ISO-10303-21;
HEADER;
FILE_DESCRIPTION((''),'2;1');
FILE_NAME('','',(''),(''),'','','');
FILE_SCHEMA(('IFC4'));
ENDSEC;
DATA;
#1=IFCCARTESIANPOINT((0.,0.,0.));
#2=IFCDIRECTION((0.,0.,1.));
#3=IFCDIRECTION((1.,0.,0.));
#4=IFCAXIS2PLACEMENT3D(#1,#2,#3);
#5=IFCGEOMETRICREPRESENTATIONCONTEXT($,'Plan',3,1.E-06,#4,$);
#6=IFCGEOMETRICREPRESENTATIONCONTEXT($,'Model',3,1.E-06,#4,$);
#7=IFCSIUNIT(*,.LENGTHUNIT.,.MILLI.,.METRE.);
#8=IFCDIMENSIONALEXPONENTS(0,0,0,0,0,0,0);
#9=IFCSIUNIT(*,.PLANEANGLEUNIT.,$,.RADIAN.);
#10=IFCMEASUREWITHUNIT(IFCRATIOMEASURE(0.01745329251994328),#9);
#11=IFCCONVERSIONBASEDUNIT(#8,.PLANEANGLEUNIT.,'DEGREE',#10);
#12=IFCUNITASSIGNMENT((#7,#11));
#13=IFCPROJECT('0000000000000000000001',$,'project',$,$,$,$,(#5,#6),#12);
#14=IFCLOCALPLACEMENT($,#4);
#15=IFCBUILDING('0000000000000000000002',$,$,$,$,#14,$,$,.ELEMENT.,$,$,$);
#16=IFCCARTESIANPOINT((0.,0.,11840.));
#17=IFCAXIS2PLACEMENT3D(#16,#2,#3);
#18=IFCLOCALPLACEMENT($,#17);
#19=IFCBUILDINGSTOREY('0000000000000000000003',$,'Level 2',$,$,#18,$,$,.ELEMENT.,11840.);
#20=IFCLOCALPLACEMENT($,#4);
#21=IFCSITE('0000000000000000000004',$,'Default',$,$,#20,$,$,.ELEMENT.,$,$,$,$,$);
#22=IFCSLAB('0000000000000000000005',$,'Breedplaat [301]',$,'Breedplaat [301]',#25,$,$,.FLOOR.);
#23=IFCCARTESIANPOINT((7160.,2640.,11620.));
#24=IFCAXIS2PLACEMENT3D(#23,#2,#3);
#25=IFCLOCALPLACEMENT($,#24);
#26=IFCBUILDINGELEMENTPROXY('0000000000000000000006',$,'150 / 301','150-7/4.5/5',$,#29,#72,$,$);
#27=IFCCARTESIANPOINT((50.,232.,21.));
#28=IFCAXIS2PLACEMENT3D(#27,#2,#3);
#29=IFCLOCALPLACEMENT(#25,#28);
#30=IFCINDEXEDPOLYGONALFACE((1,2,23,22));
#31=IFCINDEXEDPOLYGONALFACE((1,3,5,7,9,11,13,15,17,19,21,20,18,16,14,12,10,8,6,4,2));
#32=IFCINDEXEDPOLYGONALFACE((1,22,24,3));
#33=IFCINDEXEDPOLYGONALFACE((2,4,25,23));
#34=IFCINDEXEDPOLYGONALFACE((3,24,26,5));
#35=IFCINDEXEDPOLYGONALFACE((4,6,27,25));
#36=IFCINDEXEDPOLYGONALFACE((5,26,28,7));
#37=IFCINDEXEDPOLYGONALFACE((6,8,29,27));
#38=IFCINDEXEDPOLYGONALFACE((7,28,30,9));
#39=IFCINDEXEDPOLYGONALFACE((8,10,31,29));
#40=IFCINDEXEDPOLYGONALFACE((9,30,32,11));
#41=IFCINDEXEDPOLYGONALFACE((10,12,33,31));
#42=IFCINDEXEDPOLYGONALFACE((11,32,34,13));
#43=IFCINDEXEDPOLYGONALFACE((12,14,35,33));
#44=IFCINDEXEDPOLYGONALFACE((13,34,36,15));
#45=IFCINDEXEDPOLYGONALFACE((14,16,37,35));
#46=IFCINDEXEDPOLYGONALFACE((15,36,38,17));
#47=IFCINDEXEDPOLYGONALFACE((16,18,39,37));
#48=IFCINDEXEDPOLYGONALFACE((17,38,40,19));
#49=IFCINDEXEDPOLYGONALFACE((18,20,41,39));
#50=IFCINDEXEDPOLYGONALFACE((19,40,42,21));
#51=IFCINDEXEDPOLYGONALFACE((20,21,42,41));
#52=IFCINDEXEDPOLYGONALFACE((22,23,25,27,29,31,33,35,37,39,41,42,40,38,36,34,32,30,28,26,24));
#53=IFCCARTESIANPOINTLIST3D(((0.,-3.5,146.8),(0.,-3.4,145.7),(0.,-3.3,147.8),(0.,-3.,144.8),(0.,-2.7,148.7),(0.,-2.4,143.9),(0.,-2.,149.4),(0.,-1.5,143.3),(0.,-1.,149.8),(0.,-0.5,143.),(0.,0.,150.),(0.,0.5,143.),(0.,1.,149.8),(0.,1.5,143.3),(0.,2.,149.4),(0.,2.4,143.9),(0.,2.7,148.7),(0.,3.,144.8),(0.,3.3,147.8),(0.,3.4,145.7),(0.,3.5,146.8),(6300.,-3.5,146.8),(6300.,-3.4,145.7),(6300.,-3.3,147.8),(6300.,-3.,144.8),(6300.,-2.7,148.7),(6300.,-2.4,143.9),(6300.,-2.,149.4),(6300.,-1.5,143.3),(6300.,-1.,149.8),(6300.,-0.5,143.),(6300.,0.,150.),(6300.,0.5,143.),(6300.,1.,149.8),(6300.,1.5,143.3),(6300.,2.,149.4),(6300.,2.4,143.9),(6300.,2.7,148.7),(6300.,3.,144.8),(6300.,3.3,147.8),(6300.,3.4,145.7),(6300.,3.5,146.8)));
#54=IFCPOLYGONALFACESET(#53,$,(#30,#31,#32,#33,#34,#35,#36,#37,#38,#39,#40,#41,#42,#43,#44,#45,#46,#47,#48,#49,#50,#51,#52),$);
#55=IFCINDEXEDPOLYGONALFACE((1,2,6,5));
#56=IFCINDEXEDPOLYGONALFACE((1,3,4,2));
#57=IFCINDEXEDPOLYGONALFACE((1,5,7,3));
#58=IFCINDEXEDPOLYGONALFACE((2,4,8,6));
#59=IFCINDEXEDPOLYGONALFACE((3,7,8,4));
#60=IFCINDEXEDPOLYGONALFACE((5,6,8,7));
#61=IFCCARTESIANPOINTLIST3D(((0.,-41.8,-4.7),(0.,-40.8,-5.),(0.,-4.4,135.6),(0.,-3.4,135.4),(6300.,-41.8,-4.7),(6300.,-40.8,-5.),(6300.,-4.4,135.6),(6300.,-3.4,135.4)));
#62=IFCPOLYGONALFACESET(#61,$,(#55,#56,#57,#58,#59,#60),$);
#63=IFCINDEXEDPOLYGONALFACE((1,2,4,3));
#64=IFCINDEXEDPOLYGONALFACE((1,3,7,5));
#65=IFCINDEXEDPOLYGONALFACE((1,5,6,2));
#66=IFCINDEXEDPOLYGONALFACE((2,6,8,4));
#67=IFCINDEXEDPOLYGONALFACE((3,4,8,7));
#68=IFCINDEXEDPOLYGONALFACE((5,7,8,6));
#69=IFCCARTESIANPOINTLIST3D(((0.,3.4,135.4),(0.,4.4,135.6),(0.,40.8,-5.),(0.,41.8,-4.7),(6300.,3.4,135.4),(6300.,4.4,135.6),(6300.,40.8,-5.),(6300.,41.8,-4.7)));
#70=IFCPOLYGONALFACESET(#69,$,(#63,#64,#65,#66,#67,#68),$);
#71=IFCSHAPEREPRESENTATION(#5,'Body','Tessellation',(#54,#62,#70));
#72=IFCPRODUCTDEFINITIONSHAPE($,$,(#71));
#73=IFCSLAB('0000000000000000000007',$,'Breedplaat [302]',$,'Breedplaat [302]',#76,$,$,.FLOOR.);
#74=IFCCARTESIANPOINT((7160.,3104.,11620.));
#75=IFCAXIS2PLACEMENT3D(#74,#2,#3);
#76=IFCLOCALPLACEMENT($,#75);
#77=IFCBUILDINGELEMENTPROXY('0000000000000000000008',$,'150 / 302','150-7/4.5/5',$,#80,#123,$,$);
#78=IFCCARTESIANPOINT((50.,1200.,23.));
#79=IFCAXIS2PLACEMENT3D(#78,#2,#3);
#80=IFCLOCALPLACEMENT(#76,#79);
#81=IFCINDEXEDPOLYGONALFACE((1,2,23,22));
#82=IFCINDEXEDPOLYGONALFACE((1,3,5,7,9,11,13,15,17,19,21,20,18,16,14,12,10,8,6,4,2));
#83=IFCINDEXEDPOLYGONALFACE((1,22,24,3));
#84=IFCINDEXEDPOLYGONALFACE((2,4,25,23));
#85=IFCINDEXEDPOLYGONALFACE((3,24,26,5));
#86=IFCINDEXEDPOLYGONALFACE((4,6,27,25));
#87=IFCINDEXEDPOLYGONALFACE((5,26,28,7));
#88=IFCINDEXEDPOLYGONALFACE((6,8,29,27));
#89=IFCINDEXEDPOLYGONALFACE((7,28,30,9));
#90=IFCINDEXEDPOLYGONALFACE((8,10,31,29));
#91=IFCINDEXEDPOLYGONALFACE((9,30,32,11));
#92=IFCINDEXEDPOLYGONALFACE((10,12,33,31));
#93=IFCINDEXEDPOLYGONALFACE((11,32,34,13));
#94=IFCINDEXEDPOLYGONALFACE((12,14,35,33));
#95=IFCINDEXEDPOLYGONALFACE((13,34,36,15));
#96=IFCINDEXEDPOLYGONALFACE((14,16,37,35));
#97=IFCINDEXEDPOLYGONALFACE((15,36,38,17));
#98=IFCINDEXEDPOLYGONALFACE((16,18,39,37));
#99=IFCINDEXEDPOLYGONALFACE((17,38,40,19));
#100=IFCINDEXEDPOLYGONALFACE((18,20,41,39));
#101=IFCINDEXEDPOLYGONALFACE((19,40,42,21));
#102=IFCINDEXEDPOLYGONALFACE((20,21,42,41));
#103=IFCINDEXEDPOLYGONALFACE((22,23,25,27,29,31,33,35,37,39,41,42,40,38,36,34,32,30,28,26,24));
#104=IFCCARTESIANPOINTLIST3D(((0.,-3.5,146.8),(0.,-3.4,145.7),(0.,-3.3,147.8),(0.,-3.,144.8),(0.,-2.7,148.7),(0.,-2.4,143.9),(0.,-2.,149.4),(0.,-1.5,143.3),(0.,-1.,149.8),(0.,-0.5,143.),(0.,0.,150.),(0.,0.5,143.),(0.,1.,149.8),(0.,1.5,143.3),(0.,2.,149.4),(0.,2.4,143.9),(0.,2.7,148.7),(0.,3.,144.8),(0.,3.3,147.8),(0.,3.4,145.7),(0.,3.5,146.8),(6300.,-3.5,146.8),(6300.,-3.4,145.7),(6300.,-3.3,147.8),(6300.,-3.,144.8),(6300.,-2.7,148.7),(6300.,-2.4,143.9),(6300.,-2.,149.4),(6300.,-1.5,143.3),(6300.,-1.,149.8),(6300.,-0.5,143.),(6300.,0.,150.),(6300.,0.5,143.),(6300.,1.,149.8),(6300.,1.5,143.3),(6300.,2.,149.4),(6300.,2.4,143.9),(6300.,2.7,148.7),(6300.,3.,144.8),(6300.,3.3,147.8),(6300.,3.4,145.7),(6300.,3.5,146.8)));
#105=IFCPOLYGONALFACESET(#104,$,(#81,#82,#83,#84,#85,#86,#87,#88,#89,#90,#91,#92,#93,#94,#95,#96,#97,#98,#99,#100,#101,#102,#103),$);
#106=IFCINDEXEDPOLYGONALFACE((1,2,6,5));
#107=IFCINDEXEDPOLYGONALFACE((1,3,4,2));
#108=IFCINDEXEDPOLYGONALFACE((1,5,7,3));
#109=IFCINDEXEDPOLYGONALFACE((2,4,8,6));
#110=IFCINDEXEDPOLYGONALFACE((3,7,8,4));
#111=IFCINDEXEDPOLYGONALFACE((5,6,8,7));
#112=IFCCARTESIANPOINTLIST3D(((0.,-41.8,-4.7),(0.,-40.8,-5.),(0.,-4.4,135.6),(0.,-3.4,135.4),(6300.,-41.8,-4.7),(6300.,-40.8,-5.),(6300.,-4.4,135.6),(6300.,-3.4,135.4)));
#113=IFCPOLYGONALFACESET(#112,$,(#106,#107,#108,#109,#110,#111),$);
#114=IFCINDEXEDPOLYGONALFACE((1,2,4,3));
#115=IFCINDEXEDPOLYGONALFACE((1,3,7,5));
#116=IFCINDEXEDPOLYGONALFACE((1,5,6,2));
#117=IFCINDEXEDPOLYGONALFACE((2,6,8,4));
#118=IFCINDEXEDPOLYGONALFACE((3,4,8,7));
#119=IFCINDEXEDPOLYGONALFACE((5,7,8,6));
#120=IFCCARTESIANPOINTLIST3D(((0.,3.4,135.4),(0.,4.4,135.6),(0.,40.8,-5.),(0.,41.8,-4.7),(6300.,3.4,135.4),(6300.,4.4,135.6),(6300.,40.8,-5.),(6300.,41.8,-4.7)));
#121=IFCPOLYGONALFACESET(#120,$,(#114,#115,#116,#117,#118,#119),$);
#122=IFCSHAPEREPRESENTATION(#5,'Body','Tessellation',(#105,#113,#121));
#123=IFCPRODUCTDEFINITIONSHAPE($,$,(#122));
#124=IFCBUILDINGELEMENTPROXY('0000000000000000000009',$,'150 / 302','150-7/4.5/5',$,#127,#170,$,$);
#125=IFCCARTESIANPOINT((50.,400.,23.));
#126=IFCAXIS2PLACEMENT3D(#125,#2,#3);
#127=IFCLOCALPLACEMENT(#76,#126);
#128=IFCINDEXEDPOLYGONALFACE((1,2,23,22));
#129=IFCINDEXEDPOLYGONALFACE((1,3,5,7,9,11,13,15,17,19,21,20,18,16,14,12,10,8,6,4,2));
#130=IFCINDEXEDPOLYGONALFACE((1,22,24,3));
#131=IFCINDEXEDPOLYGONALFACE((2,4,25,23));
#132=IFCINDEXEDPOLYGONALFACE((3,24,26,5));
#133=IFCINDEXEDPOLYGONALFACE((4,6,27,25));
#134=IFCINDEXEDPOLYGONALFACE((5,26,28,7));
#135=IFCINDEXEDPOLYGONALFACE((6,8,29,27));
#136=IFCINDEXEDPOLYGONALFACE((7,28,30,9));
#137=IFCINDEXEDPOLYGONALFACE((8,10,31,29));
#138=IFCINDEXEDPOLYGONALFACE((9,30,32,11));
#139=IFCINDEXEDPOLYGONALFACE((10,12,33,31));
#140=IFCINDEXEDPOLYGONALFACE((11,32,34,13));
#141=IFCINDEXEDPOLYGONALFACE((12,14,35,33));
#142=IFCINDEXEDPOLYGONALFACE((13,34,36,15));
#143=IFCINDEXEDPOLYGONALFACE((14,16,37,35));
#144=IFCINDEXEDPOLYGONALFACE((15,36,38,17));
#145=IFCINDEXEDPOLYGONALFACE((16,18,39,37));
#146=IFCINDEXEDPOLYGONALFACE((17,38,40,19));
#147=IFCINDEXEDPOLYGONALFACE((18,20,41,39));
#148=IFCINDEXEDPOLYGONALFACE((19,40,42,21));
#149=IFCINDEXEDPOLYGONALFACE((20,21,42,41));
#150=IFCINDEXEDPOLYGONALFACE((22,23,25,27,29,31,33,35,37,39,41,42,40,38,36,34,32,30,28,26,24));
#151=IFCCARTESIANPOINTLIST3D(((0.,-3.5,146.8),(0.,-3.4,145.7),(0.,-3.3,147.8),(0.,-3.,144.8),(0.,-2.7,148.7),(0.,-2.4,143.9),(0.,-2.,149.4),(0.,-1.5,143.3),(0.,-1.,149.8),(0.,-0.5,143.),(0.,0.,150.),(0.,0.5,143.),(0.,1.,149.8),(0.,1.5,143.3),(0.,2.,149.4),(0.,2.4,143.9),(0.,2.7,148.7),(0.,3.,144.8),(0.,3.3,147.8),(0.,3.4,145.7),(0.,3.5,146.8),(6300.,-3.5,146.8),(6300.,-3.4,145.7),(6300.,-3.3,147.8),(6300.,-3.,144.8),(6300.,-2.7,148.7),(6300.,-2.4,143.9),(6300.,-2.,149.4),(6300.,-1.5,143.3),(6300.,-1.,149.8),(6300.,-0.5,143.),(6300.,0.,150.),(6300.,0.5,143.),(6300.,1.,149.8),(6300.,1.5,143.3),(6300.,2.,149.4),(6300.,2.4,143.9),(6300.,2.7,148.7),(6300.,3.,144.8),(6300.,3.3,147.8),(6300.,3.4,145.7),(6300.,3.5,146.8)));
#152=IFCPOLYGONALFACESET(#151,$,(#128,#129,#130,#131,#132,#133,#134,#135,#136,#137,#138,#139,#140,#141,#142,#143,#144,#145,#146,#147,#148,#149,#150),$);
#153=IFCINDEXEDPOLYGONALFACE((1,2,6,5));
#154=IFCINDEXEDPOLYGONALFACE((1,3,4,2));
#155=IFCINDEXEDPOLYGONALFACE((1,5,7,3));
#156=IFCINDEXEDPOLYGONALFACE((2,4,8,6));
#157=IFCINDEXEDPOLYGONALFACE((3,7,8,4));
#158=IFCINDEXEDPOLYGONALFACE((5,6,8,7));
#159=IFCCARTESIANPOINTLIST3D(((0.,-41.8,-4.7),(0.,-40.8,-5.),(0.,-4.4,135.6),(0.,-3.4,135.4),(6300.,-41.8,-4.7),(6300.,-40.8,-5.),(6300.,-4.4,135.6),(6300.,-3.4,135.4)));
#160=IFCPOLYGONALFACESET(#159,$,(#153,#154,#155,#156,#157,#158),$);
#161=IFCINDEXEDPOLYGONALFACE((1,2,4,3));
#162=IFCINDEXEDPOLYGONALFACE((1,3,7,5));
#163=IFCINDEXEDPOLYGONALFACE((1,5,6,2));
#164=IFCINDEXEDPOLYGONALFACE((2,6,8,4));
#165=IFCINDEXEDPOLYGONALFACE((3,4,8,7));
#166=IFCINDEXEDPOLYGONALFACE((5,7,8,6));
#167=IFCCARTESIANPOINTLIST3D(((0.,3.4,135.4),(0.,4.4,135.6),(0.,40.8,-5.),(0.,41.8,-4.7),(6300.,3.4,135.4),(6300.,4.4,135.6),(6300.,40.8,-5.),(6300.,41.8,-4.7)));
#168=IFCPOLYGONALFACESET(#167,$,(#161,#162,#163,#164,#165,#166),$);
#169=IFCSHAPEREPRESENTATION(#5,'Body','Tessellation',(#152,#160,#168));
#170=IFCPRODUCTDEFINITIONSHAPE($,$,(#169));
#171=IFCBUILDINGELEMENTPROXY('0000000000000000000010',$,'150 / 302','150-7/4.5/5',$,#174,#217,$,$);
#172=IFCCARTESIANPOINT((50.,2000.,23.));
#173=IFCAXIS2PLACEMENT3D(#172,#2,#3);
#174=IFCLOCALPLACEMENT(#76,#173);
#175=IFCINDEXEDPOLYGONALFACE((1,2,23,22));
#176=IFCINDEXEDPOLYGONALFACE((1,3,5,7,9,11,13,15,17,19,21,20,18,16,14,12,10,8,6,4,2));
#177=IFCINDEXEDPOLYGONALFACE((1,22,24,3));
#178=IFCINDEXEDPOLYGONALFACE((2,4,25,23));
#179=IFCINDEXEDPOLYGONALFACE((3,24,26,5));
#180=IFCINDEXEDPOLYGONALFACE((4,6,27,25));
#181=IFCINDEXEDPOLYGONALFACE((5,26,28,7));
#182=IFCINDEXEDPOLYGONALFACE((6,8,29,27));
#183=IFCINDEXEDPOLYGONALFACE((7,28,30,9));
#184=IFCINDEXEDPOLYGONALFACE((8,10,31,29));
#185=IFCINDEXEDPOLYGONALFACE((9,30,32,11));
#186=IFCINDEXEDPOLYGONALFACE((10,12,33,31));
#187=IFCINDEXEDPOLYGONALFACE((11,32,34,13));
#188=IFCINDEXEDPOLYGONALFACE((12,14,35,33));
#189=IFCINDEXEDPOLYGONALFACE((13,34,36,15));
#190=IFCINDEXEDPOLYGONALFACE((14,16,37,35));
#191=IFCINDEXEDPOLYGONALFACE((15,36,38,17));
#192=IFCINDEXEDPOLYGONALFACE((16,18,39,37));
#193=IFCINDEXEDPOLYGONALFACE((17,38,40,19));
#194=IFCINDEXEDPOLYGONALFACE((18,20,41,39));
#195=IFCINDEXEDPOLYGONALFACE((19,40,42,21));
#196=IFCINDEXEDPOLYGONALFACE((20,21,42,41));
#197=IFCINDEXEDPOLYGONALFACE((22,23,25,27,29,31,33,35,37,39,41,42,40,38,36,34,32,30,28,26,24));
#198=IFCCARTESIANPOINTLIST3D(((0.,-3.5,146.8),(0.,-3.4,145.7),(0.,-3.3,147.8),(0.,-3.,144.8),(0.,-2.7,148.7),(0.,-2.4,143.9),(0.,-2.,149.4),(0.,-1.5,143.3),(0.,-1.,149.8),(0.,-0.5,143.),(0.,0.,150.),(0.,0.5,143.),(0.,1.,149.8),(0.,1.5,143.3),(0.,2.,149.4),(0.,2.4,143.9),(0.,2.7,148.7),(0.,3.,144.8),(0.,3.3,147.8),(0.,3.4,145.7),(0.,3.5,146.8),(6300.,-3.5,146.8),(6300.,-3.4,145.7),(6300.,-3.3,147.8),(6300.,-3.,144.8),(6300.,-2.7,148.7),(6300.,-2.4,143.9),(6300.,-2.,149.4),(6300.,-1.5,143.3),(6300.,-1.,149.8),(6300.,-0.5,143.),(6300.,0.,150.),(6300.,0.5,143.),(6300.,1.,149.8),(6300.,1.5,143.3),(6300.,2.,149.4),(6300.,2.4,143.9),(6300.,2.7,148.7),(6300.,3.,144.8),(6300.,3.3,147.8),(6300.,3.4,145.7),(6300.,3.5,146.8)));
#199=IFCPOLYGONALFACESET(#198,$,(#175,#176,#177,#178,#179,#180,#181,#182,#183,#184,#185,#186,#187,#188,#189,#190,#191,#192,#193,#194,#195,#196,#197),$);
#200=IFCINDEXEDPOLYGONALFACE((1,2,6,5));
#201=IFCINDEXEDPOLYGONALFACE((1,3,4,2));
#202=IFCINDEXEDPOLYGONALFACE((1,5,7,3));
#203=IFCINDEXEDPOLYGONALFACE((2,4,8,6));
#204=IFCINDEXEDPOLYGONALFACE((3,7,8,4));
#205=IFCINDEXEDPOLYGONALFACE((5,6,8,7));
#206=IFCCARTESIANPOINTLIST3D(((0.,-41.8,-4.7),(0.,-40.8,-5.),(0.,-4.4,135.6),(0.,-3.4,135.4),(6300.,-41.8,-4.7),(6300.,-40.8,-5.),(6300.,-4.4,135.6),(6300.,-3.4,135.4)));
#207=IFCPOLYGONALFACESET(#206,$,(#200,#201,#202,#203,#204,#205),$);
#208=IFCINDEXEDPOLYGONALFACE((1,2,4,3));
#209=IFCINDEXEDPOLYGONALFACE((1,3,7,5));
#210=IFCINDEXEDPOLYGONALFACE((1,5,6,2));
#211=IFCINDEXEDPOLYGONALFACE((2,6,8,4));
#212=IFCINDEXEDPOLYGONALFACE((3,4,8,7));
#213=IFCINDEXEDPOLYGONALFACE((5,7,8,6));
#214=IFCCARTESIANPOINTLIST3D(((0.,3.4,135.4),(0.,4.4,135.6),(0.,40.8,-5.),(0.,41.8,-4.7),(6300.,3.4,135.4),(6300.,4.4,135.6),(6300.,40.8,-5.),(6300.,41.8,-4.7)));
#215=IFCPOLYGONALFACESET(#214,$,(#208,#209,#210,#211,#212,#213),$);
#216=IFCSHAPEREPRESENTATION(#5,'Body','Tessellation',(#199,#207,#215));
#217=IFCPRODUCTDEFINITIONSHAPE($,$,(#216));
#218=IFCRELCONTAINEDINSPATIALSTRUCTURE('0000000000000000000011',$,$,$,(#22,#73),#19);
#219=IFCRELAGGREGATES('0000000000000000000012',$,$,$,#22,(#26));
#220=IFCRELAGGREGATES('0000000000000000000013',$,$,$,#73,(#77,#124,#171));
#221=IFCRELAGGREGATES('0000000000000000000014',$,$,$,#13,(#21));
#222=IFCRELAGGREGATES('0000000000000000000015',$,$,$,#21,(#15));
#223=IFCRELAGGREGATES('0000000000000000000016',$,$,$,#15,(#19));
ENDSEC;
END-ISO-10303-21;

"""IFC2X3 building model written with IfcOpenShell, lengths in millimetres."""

from ifc_helpers import new_model, entity, si_unit, converted_unit, frame, origin_with_axes, origin_2d_with_axis, place, context, project, spatial, rectangle, circle, extrude, element, aggregate, save


model = new_model("IFC2X3")

# Units and contexts
plan_context = context("Plan", 3, precision=1e-06, world=origin_with_axes())
model_context = context("Model", 3, precision=1e-06, world=origin_with_axes())
ifc_project = project(units=[si_unit("LENGTHUNIT", "METRE", prefix="MILLI"), converted_unit("PLANEANGLEUNIT", "DEGREE", entity("IfcRatioMeasure", 0.01745329251994328), si_unit("PLANEANGLEUNIT", "RADIAN"), dimensions=[0, 0, 0, 0, 0, 0, 0])], contexts=[plan_context, model_context])

# Site, building, storey
site_placement = place(None, origin_with_axes())
site = spatial("IfcSite", under=ifc_project, at=site_placement, Name="Default", CompositionType="ELEMENT")
building_placement = place(None, origin_with_axes())
building = spatial("IfcBuilding", under=site, at=building_placement, CompositionType="ELEMENT")
storey_placement = place(None, frame((0.0, 0.0, 11840.0), z_axis=(0.0, 0.0, 1.0), x_axis=(1.0, 0.0, 0.0)))
storey = spatial("IfcBuildingStorey", under=building, at=storey_placement, Name="Level 2", CompositionType="ELEMENT", Elevation=11840.0)

# Slab, building element proxy
slab_1_placement = place(None, frame((7160.0, 2640.0, 11620.0), z_axis=(0.0, 0.0, 1.0), x_axis=(1.0, 0.0, 0.0)))
slab_1 = element("IfcSlab", 1, at=slab_1_placement, inside=storey, Name="Breedplaat [301]", ObjectType="Breedplaat [301]", PredefinedType="FLOOR")
proxy_1_placement = place(slab_1_placement, frame((50.0, 232.0, 21.0), z_axis=(0.0, 0.0, 1.0), x_axis=(1.0, 0.0, 0.0)))
proxy_1 = element("IfcBuildingElementProxy", 2, at=proxy_1_placement, Name="150 / 301", Description="150-7/4.5/5", context=plan_context, shape_type="SweptSolid", body=[
    extrude(circle(Radius=3.5, at=origin_2d_with_axis()), frame((0.0, 0.0, 146.5), z_axis=(1.0, 0.0, 0.0), x_axis=(0.0, 0.0, 1.0)), (0.0, 0.0, 1.0), 6300.0),
    extrude(rectangle(XDim=145.2, YDim=1.0, at=origin_2d_with_axis()), frame((0.0, -22.6, 65.3), z_axis=(1.0, 0.0, 0.0), x_axis=(0.0, 0.257663, 0.966235)), (0.0, 0.0, 1.0), 6300.0),
    extrude(rectangle(XDim=145.2, YDim=1.0, at=origin_2d_with_axis()), frame((0.0, 22.6, 65.3), z_axis=(1.0, 0.0, 0.0), x_axis=(0.0, -0.257663, 0.966235)), (0.0, 0.0, 1.0), 6300.0),
])
aggregate(slab_1, [proxy_1])

# Slab, building element proxies
slab_2_placement = place(None, frame((7160.0, 3104.0, 11620.0), z_axis=(0.0, 0.0, 1.0), x_axis=(1.0, 0.0, 0.0)))
slab_2 = element("IfcSlab", 3, at=slab_2_placement, inside=storey, Name="Breedplaat [302]", ObjectType="Breedplaat [302]", PredefinedType="FLOOR")
proxy_2_placement = place(slab_2_placement, frame((50.0, 1200.0, 23.0), z_axis=(0.0, 0.0, 1.0), x_axis=(1.0, 0.0, 0.0)))
proxy_2 = element("IfcBuildingElementProxy", 4, at=proxy_2_placement, Name="150 / 302", Description="150-7/4.5/5", context=plan_context, shape_type="SweptSolid", body=[
    extrude(circle(Radius=3.5, at=origin_2d_with_axis()), frame((0.0, 0.0, 146.5), z_axis=(1.0, 0.0, 0.0), x_axis=(0.0, 0.0, 1.0)), (0.0, 0.0, 1.0), 6300.0),
    extrude(rectangle(XDim=145.2, YDim=1.0, at=origin_2d_with_axis()), frame((0.0, -22.6, 65.3), z_axis=(1.0, 0.0, 0.0), x_axis=(0.0, 0.257663, 0.966235)), (0.0, 0.0, 1.0), 6300.0),
    extrude(rectangle(XDim=145.2, YDim=1.0, at=origin_2d_with_axis()), frame((0.0, 22.6, 65.3), z_axis=(1.0, 0.0, 0.0), x_axis=(0.0, -0.257663, 0.966235)), (0.0, 0.0, 1.0), 6300.0),
])
proxy_3_placement = place(slab_2_placement, frame((50.0, 400.0, 23.0), z_axis=(0.0, 0.0, 1.0), x_axis=(1.0, 0.0, 0.0)))
proxy_3 = element("IfcBuildingElementProxy", 5, at=proxy_3_placement, Name="150 / 302", Description="150-7/4.5/5", context=plan_context, shape_type="SweptSolid", body=[
    extrude(circle(Radius=3.5, at=origin_2d_with_axis()), frame((0.0, 0.0, 146.5), z_axis=(1.0, 0.0, 0.0), x_axis=(0.0, 0.0, 1.0)), (0.0, 0.0, 1.0), 6300.0),
    extrude(rectangle(XDim=145.2, YDim=1.0, at=origin_2d_with_axis()), frame((0.0, -22.6, 65.3), z_axis=(1.0, 0.0, 0.0), x_axis=(0.0, 0.257663, 0.966235)), (0.0, 0.0, 1.0), 6300.0),
    extrude(rectangle(XDim=145.2, YDim=1.0, at=origin_2d_with_axis()), frame((0.0, 22.6, 65.3), z_axis=(1.0, 0.0, 0.0), x_axis=(0.0, -0.257663, 0.966235)), (0.0, 0.0, 1.0), 6300.0),
])
proxy_4_placement = place(slab_2_placement, frame((50.0, 2000.0, 23.0), z_axis=(0.0, 0.0, 1.0), x_axis=(1.0, 0.0, 0.0)))
proxy_4 = element("IfcBuildingElementProxy", 6, at=proxy_4_placement, Name="150 / 302", Description="150-7/4.5/5", context=plan_context, shape_type="SweptSolid", body=[
    extrude(circle(Radius=3.5, at=origin_2d_with_axis()), frame((0.0, 0.0, 146.5), z_axis=(1.0, 0.0, 0.0), x_axis=(0.0, 0.0, 1.0)), (0.0, 0.0, 1.0), 6300.0),
    extrude(rectangle(XDim=145.2, YDim=1.0, at=origin_2d_with_axis()), frame((0.0, -22.6, 65.3), z_axis=(1.0, 0.0, 0.0), x_axis=(0.0, 0.257663, 0.966235)), (0.0, 0.0, 1.0), 6300.0),
    extrude(rectangle(XDim=145.2, YDim=1.0, at=origin_2d_with_axis()), frame((0.0, 22.6, 65.3), z_axis=(1.0, 0.0, 0.0), x_axis=(0.0, -0.257663, 0.966235)), (0.0, 0.0, 1.0), 6300.0),
])
aggregate(slab_2, [proxy_2, proxy_3, proxy_4])

save(model, "model.ifc")
